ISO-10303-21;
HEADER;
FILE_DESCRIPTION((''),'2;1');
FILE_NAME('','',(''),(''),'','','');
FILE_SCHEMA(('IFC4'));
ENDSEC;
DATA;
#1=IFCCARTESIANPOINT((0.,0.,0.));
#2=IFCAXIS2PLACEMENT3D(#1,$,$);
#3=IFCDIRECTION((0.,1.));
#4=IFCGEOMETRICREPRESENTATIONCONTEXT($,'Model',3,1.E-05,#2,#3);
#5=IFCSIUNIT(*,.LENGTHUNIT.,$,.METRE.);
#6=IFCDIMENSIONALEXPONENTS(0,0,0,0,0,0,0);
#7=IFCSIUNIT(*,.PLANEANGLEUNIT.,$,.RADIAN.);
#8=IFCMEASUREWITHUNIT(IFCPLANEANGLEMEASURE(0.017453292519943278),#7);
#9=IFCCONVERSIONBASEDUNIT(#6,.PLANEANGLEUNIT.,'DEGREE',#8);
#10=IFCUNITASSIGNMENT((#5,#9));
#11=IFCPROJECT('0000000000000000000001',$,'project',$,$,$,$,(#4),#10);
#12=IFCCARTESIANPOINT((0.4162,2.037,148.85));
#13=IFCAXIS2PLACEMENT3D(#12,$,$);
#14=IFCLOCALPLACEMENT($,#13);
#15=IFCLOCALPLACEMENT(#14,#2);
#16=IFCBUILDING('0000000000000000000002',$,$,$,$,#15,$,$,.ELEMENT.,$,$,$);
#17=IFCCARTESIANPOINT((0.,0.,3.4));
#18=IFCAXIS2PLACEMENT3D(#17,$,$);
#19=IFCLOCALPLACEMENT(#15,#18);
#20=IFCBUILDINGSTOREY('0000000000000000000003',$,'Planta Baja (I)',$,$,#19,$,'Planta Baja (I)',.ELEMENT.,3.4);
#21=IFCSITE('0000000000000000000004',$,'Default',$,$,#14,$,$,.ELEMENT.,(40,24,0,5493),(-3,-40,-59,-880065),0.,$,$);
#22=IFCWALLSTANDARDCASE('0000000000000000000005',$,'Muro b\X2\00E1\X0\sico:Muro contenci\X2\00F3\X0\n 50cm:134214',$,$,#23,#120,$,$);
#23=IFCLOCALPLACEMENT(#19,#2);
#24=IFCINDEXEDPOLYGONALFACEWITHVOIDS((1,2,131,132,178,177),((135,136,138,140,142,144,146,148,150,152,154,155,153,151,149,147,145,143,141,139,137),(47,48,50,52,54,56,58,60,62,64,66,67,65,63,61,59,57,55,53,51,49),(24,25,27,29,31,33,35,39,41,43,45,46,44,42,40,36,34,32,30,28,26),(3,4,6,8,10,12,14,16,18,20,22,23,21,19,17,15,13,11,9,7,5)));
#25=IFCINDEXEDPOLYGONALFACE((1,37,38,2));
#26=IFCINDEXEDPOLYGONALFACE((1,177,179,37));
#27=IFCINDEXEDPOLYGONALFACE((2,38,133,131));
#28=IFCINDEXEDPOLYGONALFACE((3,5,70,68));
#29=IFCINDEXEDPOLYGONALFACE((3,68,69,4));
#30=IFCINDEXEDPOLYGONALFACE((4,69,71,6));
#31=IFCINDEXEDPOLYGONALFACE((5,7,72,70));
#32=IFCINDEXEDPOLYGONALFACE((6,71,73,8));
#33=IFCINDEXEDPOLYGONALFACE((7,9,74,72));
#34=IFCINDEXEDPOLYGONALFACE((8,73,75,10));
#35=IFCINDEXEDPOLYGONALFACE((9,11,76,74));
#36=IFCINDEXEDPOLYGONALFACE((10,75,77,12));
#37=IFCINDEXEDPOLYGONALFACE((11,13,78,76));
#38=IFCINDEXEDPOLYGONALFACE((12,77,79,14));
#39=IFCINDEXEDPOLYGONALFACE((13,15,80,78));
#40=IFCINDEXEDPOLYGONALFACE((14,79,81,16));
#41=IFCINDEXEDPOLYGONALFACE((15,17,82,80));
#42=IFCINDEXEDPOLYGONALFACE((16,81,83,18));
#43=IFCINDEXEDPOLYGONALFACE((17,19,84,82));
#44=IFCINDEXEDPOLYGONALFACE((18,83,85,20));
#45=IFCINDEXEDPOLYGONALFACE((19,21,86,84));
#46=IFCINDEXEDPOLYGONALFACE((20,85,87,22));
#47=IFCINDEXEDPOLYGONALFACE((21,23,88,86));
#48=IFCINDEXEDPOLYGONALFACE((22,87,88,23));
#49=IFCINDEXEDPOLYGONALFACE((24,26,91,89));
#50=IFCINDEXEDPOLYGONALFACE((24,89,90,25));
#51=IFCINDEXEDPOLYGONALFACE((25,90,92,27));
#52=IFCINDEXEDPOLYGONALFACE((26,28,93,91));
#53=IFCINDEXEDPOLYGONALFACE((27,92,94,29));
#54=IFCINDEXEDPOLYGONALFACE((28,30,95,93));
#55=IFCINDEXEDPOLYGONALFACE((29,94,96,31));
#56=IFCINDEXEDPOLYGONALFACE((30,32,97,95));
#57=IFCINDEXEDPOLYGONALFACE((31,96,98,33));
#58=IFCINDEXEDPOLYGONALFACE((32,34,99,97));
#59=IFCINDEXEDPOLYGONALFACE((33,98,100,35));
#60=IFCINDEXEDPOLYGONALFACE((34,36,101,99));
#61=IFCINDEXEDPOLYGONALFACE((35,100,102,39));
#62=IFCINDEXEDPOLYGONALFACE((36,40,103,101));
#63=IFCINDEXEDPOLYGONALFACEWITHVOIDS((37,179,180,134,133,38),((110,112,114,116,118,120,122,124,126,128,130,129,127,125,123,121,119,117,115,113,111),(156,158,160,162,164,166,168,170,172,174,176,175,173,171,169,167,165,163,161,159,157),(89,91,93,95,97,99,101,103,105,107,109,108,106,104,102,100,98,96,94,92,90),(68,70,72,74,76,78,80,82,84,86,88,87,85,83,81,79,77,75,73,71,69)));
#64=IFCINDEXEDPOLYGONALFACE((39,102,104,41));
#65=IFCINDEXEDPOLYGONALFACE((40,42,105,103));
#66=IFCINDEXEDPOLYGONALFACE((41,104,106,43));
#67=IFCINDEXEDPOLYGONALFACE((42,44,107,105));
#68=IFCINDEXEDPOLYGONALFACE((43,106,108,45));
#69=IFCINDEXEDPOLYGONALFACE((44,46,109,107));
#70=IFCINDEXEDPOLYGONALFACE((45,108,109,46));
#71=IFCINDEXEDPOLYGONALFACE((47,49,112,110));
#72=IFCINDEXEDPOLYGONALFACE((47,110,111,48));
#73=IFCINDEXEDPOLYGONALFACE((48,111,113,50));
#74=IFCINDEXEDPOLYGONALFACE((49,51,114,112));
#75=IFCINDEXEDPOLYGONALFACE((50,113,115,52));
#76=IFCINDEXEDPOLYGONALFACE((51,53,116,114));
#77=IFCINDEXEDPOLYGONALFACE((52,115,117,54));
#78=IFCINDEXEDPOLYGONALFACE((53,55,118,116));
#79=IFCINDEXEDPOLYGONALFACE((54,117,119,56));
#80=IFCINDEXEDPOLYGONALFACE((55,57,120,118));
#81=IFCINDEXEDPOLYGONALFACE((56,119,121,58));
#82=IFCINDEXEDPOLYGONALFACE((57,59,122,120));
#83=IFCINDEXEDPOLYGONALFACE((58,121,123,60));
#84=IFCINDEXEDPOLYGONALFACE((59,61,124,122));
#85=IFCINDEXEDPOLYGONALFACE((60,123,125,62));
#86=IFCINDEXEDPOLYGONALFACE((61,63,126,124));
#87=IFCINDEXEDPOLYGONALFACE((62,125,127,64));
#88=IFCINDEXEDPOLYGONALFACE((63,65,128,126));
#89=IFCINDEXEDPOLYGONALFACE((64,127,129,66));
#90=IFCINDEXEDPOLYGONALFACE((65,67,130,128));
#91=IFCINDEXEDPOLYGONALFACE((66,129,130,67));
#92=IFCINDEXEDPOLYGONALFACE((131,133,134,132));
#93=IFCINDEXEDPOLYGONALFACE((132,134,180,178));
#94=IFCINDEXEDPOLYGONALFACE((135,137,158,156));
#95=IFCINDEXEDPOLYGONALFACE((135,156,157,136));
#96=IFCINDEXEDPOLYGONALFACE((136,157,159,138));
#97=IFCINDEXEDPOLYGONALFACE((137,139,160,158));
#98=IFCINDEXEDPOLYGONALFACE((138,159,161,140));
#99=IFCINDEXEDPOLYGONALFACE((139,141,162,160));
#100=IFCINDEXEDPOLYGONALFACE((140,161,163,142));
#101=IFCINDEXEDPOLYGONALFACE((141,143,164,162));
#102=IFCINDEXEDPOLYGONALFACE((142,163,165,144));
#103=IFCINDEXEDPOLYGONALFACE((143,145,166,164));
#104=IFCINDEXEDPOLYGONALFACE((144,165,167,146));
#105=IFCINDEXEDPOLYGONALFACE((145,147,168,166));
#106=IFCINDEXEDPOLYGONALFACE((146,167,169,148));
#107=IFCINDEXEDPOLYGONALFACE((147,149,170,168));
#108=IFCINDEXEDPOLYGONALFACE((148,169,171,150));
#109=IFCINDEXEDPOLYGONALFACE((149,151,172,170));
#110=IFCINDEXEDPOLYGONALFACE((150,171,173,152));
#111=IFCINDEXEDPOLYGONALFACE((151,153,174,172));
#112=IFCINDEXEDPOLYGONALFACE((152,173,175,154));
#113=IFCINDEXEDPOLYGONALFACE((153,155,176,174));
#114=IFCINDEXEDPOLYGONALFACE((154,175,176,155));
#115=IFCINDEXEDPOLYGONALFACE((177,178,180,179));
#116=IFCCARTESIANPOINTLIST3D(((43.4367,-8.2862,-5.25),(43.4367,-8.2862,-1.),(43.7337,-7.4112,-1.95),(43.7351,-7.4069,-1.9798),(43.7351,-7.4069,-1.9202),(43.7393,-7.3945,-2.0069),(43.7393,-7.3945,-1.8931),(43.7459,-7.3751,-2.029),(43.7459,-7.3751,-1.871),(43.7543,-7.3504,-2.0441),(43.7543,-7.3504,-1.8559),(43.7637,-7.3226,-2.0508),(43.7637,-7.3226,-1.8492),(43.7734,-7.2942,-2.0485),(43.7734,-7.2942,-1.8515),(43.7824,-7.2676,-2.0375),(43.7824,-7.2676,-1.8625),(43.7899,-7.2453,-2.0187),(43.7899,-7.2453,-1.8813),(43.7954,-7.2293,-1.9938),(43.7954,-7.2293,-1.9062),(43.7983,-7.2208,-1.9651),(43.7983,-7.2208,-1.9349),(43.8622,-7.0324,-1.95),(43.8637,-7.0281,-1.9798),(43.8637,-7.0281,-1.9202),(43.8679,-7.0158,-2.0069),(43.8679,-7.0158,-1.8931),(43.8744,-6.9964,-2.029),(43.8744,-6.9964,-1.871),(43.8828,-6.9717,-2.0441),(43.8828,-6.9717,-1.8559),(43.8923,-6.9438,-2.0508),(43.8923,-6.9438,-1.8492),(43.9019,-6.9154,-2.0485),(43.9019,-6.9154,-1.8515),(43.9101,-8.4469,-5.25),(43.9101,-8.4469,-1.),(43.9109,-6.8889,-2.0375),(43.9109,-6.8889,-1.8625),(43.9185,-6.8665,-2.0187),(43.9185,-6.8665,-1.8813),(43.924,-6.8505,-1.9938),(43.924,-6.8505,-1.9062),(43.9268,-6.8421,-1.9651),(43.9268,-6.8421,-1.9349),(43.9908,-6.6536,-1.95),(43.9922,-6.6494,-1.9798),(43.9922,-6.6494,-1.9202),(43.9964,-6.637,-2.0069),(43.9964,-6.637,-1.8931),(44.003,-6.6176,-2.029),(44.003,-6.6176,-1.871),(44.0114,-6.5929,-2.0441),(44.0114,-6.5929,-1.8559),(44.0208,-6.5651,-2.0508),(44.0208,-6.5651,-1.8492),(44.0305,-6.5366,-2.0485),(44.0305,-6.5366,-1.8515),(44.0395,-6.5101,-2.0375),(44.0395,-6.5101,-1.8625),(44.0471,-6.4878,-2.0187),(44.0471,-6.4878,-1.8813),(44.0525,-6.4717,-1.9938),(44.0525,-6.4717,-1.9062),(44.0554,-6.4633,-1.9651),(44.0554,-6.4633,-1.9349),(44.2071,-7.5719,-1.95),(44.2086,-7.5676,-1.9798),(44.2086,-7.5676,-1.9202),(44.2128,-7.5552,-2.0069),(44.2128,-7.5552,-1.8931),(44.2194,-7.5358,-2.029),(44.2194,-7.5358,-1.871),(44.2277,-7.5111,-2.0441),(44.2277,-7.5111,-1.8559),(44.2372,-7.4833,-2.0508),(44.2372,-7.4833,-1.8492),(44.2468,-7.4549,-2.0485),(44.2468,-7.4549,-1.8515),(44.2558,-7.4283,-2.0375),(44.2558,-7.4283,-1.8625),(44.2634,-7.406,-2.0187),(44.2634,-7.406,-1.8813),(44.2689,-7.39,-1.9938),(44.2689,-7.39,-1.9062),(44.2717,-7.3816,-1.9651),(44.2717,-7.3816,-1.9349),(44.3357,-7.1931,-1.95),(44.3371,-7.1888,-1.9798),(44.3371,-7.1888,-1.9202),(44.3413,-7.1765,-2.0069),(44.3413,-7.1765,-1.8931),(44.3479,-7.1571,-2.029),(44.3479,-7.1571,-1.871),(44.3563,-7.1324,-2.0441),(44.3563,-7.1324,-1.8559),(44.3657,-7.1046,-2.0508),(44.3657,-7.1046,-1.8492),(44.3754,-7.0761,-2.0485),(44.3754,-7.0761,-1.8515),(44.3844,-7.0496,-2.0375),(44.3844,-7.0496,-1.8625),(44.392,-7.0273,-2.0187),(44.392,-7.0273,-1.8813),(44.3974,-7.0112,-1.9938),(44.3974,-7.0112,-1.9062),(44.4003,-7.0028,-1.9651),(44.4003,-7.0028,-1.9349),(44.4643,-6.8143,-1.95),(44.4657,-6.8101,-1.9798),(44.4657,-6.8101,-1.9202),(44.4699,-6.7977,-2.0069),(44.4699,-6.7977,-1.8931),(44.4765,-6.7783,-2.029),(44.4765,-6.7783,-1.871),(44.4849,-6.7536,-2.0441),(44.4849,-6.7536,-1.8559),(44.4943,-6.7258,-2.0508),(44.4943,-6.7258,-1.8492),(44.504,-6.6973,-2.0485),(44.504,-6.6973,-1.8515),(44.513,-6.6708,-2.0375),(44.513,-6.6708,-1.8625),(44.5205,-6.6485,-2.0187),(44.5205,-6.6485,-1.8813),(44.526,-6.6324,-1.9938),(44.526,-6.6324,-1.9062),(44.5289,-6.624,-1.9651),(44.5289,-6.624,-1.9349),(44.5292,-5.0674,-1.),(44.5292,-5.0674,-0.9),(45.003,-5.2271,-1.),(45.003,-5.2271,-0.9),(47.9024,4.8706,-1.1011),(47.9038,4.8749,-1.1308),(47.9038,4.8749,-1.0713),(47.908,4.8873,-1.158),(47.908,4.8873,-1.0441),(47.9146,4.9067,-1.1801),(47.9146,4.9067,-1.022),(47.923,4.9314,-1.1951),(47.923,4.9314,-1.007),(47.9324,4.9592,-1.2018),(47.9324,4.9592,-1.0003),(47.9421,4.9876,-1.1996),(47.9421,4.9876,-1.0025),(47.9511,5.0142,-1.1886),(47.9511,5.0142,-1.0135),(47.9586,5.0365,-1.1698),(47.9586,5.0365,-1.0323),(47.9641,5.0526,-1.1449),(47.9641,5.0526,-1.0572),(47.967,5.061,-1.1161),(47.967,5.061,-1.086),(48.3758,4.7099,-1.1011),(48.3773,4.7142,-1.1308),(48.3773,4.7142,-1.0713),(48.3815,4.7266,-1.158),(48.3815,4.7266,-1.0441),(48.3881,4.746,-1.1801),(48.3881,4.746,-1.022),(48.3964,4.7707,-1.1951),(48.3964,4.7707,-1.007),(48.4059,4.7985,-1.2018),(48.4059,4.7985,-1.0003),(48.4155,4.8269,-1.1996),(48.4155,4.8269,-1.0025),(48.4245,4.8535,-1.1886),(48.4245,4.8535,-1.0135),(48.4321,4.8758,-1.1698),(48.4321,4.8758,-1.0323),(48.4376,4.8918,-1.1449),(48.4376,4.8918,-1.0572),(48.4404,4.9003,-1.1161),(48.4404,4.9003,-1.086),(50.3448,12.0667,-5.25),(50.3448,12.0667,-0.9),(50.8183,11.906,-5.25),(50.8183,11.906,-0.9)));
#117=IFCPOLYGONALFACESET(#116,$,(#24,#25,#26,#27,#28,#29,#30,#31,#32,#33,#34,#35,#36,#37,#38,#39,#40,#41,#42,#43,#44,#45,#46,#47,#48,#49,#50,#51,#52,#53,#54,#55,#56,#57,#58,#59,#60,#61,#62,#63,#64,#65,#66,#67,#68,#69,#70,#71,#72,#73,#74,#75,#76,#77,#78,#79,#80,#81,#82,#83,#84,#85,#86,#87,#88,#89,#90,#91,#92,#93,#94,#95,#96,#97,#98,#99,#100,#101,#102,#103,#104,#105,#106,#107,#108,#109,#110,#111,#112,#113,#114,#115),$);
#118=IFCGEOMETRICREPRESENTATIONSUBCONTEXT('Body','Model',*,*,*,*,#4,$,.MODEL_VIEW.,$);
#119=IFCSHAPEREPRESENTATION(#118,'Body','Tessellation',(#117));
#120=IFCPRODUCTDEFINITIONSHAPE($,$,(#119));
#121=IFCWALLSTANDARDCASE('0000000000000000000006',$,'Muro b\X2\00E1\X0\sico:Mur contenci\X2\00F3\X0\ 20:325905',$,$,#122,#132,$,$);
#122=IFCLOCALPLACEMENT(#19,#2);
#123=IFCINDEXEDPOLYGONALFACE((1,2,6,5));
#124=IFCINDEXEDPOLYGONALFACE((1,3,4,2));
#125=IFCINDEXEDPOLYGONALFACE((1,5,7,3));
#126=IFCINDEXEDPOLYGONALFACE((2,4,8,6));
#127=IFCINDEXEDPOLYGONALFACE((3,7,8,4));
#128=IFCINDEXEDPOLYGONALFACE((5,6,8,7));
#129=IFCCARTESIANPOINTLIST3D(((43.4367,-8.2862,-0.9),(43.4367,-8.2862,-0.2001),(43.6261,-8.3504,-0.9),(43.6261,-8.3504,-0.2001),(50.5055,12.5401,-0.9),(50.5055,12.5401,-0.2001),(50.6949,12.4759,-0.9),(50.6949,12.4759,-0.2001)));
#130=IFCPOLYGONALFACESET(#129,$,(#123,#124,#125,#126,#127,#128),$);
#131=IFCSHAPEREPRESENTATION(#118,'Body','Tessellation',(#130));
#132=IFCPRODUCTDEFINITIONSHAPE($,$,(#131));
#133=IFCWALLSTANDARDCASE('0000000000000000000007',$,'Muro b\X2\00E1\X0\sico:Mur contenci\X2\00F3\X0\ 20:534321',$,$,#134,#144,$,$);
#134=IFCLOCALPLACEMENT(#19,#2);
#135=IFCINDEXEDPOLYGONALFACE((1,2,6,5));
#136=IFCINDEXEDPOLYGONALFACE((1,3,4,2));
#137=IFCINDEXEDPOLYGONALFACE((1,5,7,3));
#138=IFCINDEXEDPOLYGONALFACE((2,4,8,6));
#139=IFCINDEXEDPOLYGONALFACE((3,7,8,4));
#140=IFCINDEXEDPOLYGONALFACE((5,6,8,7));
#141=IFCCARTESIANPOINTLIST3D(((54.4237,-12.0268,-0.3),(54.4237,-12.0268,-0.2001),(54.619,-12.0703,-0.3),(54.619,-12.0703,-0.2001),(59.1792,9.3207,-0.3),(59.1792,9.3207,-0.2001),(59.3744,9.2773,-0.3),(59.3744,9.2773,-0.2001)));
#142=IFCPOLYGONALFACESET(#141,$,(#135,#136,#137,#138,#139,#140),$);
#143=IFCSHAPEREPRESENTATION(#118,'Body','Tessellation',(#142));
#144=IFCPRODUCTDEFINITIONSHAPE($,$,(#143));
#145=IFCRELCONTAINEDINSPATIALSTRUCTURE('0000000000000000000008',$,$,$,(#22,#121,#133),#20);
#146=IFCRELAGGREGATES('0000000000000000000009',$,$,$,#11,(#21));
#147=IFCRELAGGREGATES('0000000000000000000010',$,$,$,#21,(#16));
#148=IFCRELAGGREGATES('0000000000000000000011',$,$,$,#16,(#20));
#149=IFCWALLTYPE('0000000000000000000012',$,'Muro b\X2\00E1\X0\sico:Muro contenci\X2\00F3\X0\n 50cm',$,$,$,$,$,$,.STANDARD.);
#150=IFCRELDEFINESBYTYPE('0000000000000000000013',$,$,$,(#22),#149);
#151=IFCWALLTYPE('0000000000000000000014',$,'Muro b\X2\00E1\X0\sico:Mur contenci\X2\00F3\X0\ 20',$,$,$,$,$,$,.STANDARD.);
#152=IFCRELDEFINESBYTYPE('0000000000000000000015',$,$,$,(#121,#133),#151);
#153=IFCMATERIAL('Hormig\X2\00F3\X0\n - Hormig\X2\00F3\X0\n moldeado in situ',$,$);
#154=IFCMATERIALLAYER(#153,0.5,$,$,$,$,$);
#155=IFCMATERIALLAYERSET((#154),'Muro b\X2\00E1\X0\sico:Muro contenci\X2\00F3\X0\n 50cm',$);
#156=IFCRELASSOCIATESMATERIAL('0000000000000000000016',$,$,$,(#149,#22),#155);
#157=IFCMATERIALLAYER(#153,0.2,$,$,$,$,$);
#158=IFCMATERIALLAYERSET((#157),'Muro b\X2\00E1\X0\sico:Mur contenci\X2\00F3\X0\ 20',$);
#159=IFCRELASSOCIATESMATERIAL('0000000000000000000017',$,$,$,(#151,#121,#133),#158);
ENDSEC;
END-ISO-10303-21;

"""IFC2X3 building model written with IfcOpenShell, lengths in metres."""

from ifc_helpers import new_model, entity, si_unit, converted_unit, direction, frame, frame_2d, origin, origin_2d_with_axis, place, context, subcontext, project, spatial, polyline, rectangle, circle, extrude, clip, bounded_halfspace, material, layer, layer_set, layer_usage, type_object, element, save


model = new_model("IFC2X3")

# Units and contexts
model_context = context("Model", 3, precision=1e-05, world=origin(), true_north=direction((0.0, 1.0)))
body_context = subcontext(model_context, "Body", "Model", "MODEL_VIEW")
ifc_project = project(units=[si_unit("LENGTHUNIT", "METRE"), converted_unit("PLANEANGLEUNIT", "DEGREE", entity("IfcPlaneAngleMeasure", 0.017453292519943278), si_unit("PLANEANGLEUNIT", "RADIAN"), dimensions=[0, 0, 0, 0, 0, 0, 0])], contexts=[model_context])

# Site, building, storey
site_placement = place(None, frame((0.4162, 2.037, 148.85)))
site = spatial("IfcSite", under=ifc_project, at=site_placement, Name="Default", CompositionType="ELEMENT", RefLatitude=(40, 24, 0, 5493), RefLongitude=(-3, -40, -59, -880065), RefElevation=0.0)
building_placement = place(site_placement, origin())
building = spatial("IfcBuilding", under=site, at=building_placement, CompositionType="ELEMENT")
storey_placement = place(building_placement, frame((0.0, 0.0, 3.4)))
storey = spatial("IfcBuildingStorey", under=building, at=storey_placement, Name="Planta Baja (I)", LongName="Planta Baja (I)", CompositionType="ELEMENT", Elevation=3.4)

# Wall, openings
ifc_material_1 = material(Name="Hormigón - Hormigón moldeado in situ")
ifc_layer_1 = layer(ifc_material_1, 0.5)
ifc_layer_set_1 = layer_set([ifc_layer_1], Name="Muro básico:Muro contención 50cm")
ifc_layer_usage_1 = layer_usage(ifc_layer_set_1, "AXIS2", "NEGATIVE", 0.25)
wall_type_1 = type_object("IfcWallType", Name="Muro básico:Muro contención 50cm", PredefinedType="STANDARD", material=ifc_layer_set_1)
wall_1_placement = place(storey_placement, frame((43.6734, -8.3665, -5.25), z_axis=(0.0, 0.0, 1.0), x_axis=(0.321411, 0.94694, 0.0)))
wall_1 = element("IfcWallStandardCase", 1, at=wall_1_placement, inside=storey, type_object=wall_type_1, material=ifc_layer_usage_1, Name="Muro básico:Muro contención 50cm:134214", context=body_context, shape_type="Clipping", body=[
    clip(clip(extrude(rectangle(XDim=21.4933, YDim=0.5, at=frame_2d((10.7466, 0.0), x_axis=(-1.0, 0.0))), origin(), (0.0, 0.0, 1.0), 4.35), bounded_halfspace(frame((0.0, -0.25, 4.25), z_axis=(0.0, 0.0, -1.0), x_axis=(-0.99417, -0.107826, 0.0)), True, frame((0.0, -0.25, 4.25)), polyline([(0.0, 0.0), (0.5, 0.0), (3.4002, 0.0), (3.3991, 0.5), (0.0, 0.5), (0.0, 0.0)]))), bounded_halfspace(frame((3.4002, -0.25, 4.35), z_axis=(0.0, 0.0, -1.0), x_axis=(-0.99417, -0.107826, 0.0)), True, frame((3.4002, -0.25, 4.35)), polyline([(0.0, 0.0), (0.5, 0.0), (1.5, 0.0), (18.0931, 0.0), (18.0931, 0.25), (18.0931, 0.5), (-0.0011, 0.5), (0.0, 0.0)]))),
])
opening_1_placement = place(wall_1_placement, origin())
element("IfcOpeningElement", 2, at=opening_1_placement, cuts=wall_1, ObjectType="Opening", context=body_context, shape_type="SweptSolid", body=[
    extrude(rectangle(XDim=0.1993, YDim=0.2021, at=origin_2d_with_axis()), frame((-1.5248, -0.25, 3.75), z_axis=(0.0, 1.0, 0.0), x_axis=(0.0, 0.0, -1.0)), (0.0, 0.0, 1.0), 0.5),
])
opening_2_placement = place(wall_1_placement, origin())
element("IfcOpeningElement", 3, at=opening_2_placement, cuts=wall_1, ObjectType="Opening", context=body_context, shape_type="SweptSolid", body=[
    extrude(rectangle(XDim=0.1993, YDim=0.2021, at=frame_2d((0.0, 0.0), x_axis=(1.0, 0.0))), frame((-0.5748, -0.25, 3.75), z_axis=(0.0, 1.0, 0.0), x_axis=(0.0, 0.0, -1.0)), (0.0, 0.0, 1.0), 0.5),
])
opening_3_placement = place(wall_1_placement, origin())
element("IfcOpeningElement", 4, at=opening_3_placement, cuts=wall_1, ObjectType="Opening", context=body_context, shape_type="SweptSolid", body=[
    extrude(circle(Radius=0.1011, at=origin_2d_with_axis()), frame((1.0251, 0.25, 3.3), z_axis=(0.0, -1.0, 0.0), x_axis=(-1.0, 0.0, 0.0)), (0.0, 0.0, 1.0), 0.5),
])
opening_4_placement = place(wall_1_placement, origin())
element("IfcOpeningElement", 5, at=opening_4_placement, cuts=wall_1, ObjectType="Opening", context=body_context, shape_type="SweptSolid", body=[
    extrude(circle(Radius=0.1011, at=frame_2d((0.0, 0.0), x_axis=(1.0, 0.0))), frame((1.4251, 0.25, 3.3), z_axis=(0.0, -1.0, 0.0), x_axis=(-1.0, 0.0, 0.0)), (0.0, 0.0, 1.0), 0.5),
])
opening_5_placement = place(wall_1_placement, origin())
element("IfcOpeningElement", 6, at=opening_5_placement, cuts=wall_1, ObjectType="Opening", context=body_context, shape_type="SweptSolid", body=[
    extrude(circle(Radius=0.1011, at=origin_2d_with_axis()), frame((1.8251, 0.25, 3.3), z_axis=(0.0, -1.0, 0.0), x_axis=(-1.0, 0.0, 0.0)), (0.0, 0.0, 1.0), 0.5),
])
opening_6_placement = place(wall_1_placement, origin())
element("IfcOpeningElement", 7, at=opening_6_placement, cuts=wall_1, ObjectType="Opening", context=body_context, shape_type="SweptSolid", body=[
    extrude(circle(Radius=0.1011, at=origin_2d_with_axis()), frame((13.9951, 0.25, 4.1489), z_axis=(0.0, -1.0, 0.0), x_axis=(-1.0, 0.0, 0.0)), (0.0, 0.0, 1.0), 0.5),
])

# Walls
ifc_layer_2 = layer(ifc_material_1, 0.2)
ifc_layer_set_2 = layer_set([ifc_layer_2], Name="Muro básico:Mur contenció 20")
ifc_layer_usage_2 = layer_usage(ifc_layer_set_2, "AXIS2", "NEGATIVE", 0.1)
wall_type_2 = type_object("IfcWallType", Name="Muro básico:Mur contenció 20", PredefinedType="STANDARD", material=ifc_layer_set_2)
wall_2_placement = place(storey_placement, frame((50.6002, 12.508, -0.9), z_axis=(0.0, 0.0, 1.0), x_axis=(-0.321411, -0.94694, 0.0)))
element("IfcWallStandardCase", 8, at=wall_2_placement, inside=storey, type_object=wall_type_2, material=ifc_layer_usage_2, Name="Muro básico:Mur contenció 20:325905", context=body_context, shape_type="SweptSolid", body=[
    extrude(rectangle(XDim=21.9933, YDim=0.2, at=frame_2d((10.9966, 0.0), x_axis=(-1.0, 0.0))), origin(), (0.0, 0.0, 1.0), 0.6999),
])
ifc_layer_usage_3 = layer_usage(ifc_layer_set_2, "AXIS2", "NEGATIVE", 0.1)
wall_3_placement = place(storey_placement, frame((59.2768, 9.299, -0.3), z_axis=(0.0, 0.0, 1.0), x_axis=(-0.217433, -0.976075, 0.0)))
element("IfcWallStandardCase", 9, at=wall_3_placement, inside=storey, type_object=wall_type_2, material=ifc_layer_usage_3, Name="Muro básico:Mur contenció 20:534321", context=body_context, shape_type="SweptSolid", body=[
    extrude(rectangle(XDim=21.8708, YDim=0.2, at=frame_2d((10.9354, 0.0), x_axis=(-1.0, 0.0))), origin(), (0.0, 0.0, 1.0), 0.0999),
])

save(model, "model.ifc")
